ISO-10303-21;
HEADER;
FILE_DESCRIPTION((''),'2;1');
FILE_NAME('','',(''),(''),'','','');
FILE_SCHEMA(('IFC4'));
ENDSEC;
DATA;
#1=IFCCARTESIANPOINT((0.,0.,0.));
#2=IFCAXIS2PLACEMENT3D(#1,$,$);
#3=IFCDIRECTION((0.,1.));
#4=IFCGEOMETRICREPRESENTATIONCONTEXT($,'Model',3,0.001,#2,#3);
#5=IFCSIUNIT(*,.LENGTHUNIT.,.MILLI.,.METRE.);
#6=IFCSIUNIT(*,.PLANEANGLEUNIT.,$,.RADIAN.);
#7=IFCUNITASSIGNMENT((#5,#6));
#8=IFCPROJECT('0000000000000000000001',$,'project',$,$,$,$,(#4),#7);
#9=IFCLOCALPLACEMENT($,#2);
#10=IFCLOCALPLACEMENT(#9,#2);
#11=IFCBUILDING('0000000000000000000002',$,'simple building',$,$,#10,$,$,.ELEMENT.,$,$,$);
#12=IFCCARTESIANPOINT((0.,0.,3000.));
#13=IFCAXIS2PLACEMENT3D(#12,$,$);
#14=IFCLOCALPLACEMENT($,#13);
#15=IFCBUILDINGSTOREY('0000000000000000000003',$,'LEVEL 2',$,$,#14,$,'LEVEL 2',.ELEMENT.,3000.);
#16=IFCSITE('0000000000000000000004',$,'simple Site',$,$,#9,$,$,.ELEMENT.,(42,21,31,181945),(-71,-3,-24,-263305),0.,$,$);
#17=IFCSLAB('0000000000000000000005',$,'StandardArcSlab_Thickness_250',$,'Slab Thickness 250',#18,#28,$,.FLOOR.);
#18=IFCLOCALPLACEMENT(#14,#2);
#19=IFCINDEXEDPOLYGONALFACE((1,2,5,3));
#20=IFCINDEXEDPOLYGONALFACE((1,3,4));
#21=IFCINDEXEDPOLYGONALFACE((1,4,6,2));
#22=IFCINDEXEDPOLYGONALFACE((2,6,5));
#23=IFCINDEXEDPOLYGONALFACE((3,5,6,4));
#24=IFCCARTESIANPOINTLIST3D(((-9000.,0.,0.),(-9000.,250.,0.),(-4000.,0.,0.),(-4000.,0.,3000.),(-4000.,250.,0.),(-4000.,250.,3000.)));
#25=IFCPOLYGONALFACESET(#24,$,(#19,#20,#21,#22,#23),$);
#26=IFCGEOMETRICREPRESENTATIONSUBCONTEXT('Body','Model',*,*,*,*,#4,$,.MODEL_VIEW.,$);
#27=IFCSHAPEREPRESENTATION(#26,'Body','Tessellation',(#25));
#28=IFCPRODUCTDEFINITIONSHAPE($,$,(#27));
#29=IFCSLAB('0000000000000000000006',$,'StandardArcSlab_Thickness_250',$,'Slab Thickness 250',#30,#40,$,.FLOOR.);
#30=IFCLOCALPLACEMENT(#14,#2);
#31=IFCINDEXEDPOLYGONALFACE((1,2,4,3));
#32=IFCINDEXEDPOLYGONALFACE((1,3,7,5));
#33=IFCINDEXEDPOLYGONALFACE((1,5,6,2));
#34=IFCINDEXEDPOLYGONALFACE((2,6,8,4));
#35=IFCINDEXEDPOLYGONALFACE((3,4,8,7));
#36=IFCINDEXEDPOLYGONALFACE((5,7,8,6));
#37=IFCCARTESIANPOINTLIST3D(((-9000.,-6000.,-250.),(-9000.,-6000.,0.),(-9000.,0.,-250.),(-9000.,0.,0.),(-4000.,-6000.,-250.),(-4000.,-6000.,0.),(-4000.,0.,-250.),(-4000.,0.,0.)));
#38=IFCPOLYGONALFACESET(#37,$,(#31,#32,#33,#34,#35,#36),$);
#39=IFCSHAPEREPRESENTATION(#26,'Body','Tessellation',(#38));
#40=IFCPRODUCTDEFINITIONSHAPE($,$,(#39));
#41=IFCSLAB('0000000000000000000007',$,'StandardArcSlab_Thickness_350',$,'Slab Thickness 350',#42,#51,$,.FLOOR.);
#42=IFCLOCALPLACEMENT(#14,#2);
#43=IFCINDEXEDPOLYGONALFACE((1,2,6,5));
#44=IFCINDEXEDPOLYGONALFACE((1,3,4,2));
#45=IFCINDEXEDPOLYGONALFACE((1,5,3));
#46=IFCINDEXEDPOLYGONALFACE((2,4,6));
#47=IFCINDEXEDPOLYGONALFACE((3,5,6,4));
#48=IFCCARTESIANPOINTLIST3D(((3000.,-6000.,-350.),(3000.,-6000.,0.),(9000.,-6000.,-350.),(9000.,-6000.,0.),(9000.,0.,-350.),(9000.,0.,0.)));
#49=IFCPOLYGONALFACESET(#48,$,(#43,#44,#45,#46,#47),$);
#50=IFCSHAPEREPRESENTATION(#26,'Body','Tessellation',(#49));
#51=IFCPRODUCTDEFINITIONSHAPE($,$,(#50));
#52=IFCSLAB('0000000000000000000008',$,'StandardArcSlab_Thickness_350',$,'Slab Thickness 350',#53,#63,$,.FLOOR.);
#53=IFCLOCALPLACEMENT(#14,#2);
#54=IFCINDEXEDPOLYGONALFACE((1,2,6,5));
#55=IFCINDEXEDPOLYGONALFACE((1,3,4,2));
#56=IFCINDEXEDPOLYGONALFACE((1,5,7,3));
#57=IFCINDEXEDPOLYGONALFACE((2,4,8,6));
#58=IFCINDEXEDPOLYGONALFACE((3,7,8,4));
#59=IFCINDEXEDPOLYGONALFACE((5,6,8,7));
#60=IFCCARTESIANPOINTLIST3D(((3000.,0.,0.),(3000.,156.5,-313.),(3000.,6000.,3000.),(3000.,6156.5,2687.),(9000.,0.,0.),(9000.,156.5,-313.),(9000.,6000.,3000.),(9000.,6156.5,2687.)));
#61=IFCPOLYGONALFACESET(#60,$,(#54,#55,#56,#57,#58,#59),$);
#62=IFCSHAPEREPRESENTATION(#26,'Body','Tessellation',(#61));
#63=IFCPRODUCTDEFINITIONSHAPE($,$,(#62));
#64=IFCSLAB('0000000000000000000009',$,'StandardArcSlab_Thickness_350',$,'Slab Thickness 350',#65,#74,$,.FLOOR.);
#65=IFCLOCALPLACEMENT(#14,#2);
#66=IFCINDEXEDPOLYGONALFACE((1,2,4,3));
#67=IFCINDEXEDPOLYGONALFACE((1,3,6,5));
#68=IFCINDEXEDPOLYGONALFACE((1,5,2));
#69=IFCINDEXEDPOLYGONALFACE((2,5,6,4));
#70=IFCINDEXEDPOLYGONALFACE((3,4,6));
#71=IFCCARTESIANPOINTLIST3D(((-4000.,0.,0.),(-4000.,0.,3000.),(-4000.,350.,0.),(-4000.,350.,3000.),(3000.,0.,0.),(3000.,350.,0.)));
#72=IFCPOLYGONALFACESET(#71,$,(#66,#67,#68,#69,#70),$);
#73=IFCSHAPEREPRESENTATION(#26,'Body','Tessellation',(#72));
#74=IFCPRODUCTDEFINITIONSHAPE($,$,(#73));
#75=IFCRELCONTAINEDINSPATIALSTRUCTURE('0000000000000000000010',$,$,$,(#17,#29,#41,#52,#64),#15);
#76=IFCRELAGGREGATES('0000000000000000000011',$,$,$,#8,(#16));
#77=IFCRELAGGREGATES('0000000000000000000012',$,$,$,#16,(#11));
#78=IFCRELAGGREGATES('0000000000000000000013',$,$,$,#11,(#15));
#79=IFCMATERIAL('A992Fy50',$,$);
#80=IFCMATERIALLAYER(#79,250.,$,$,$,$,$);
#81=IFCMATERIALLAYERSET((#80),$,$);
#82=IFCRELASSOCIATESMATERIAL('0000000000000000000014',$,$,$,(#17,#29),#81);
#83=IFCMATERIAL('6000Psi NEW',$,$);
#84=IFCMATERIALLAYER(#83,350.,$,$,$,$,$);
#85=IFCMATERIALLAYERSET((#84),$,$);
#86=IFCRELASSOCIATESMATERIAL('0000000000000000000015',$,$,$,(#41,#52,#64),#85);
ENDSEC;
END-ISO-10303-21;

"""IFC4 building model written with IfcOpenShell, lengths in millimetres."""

from ifc_helpers import new_model, si_unit, direction, frame, origin, origin_with_axes, place, context, subcontext, project, spatial, polyline, outline, extrude, material, layer, layer_set, layer_usage, element, save


model = new_model("IFC4")

# Units and contexts
model_context = context("Model", 3, precision=0.001, world=origin(), true_north=direction((0.0, 1.0)))
body_context = subcontext(model_context, "Body", "Model", "MODEL_VIEW")
ifc_project = project(units=[si_unit("LENGTHUNIT", "METRE", prefix="MILLI"), si_unit("PLANEANGLEUNIT", "RADIAN")], contexts=[model_context])

# Site, building, storey
site_placement = place(None, origin())
site = spatial("IfcSite", under=ifc_project, at=site_placement, Name="simple Site", CompositionType="ELEMENT", RefLatitude=(42, 21, 31, 181945), RefLongitude=(-71, -3, -24, -263305), RefElevation=0.0)
building_placement = place(site_placement, origin())
building = spatial("IfcBuilding", under=site, at=building_placement, Name="simple building", CompositionType="ELEMENT")
storey_placement = place(None, frame((0.0, 0.0, 3000.0)))
storey = spatial("IfcBuildingStorey", under=building, at=storey_placement, Name="LEVEL 2", LongName="LEVEL 2", CompositionType="ELEMENT", Elevation=3000.0)

# Shared definitions
ifc_material_1 = material(Name="6000Psi NEW")

# Slabs
ifc_material_2 = material(Name="A992Fy50")
ifc_layer_1 = layer(ifc_material_2, 250.0)
ifc_layer_set_1 = layer_set([ifc_layer_1])
ifc_layer_usage_1 = layer_usage(ifc_layer_set_1, "AXIS3", "POSITIVE", -250.0)
slab_1_placement = place(None, frame((-9000.0, 250.0, 3000.0), z_axis=(0.0, -1.0, 0.0), x_axis=(1.0, 0.0, 0.0)))
element("IfcSlab", 1, at=slab_1_placement, inside=storey, material=ifc_layer_usage_1, Name="StandardArcSlab_Thickness_250", ObjectType="Slab Thickness 250", PredefinedType="FLOOR", context=body_context, shape_type="SweptSolid", body=[
    extrude(outline(polyline([(0.0, 0.0), (5000.0, 0.0), (5000.0, 3000.0), (0.0, 0.0)])), origin_with_axes(), (0.0, 0.0, 1.0), 250.0),
])
slab_2_placement = place(None, frame((-9000.0, 0.0, 2750.0), z_axis=(0.0, 0.0, 1.0), x_axis=(0.0, -1.0, 0.0)))
element("IfcSlab", 2, at=slab_2_placement, inside=storey, material=ifc_layer_usage_1, Name="StandardArcSlab_Thickness_250", ObjectType="Slab Thickness 250", PredefinedType="FLOOR", context=body_context, shape_type="SweptSolid", body=[
    extrude(outline(polyline([(0.0, 0.0), (6000.0, 0.0), (6000.0, 5000.0), (0.0, 5000.0), (0.0, 0.0)])), origin_with_axes(), (0.0, 0.0, 1.0), 250.0),
])
ifc_layer_2 = layer(ifc_material_1, 350.0)
ifc_layer_set_2 = layer_set([ifc_layer_2])
ifc_layer_usage_2 = layer_usage(ifc_layer_set_2, "AXIS3", "POSITIVE", -350.0)
slab_3_placement = place(None, frame((3000.0, -6000.0, 2650.0), z_axis=(0.0, 0.0, 1.0), x_axis=(1.0, 0.0, 0.0)))
element("IfcSlab", 3, at=slab_3_placement, inside=storey, material=ifc_layer_usage_2, Name="StandardArcSlab_Thickness_350", ObjectType="Slab Thickness 350", PredefinedType="FLOOR", context=body_context, shape_type="SweptSolid", body=[
    extrude(outline(polyline([(0.0, 0.0), (6000.0, 0.0), (6000.0, 6000.0), (0.0, 0.0)])), origin_with_axes(), (0.0, 0.0, 1.0), 350.0),
])
slab_4_placement = place(None, frame((3000.0, 156.5, 2687.0), z_axis=(0.0, -0.447214, 0.894427), x_axis=(1.0, 0.0, 0.0)))
element("IfcSlab", 4, at=slab_4_placement, inside=storey, material=ifc_layer_usage_2, Name="StandardArcSlab_Thickness_350", ObjectType="Slab Thickness 350", PredefinedType="FLOOR", context=body_context, shape_type="SweptSolid", body=[
    extrude(outline(polyline([(0.0, 0.0), (6000.0, 0.0), (6000.0, 6708.2), (0.0, 6708.2), (0.0, 0.0)])), origin_with_axes(), (0.0, 0.0, 1.0), 350.0),
])
slab_5_placement = place(None, frame((-4000.0, 350.0, 3000.0), z_axis=(0.0, -1.0, 0.0), x_axis=(1.0, 0.0, 0.0)))
element("IfcSlab", 5, at=slab_5_placement, inside=storey, material=ifc_layer_usage_2, Name="StandardArcSlab_Thickness_350", ObjectType="Slab Thickness 350", PredefinedType="FLOOR", context=body_context, shape_type="SweptSolid", body=[
    extrude(outline(polyline([(0.0, 0.0), (7000.0, 0.0), (0.0, 3000.0), (0.0, 0.0)])), origin_with_axes(), (0.0, 0.0, 1.0), 350.0),
])

save(model, "model.ifc")
